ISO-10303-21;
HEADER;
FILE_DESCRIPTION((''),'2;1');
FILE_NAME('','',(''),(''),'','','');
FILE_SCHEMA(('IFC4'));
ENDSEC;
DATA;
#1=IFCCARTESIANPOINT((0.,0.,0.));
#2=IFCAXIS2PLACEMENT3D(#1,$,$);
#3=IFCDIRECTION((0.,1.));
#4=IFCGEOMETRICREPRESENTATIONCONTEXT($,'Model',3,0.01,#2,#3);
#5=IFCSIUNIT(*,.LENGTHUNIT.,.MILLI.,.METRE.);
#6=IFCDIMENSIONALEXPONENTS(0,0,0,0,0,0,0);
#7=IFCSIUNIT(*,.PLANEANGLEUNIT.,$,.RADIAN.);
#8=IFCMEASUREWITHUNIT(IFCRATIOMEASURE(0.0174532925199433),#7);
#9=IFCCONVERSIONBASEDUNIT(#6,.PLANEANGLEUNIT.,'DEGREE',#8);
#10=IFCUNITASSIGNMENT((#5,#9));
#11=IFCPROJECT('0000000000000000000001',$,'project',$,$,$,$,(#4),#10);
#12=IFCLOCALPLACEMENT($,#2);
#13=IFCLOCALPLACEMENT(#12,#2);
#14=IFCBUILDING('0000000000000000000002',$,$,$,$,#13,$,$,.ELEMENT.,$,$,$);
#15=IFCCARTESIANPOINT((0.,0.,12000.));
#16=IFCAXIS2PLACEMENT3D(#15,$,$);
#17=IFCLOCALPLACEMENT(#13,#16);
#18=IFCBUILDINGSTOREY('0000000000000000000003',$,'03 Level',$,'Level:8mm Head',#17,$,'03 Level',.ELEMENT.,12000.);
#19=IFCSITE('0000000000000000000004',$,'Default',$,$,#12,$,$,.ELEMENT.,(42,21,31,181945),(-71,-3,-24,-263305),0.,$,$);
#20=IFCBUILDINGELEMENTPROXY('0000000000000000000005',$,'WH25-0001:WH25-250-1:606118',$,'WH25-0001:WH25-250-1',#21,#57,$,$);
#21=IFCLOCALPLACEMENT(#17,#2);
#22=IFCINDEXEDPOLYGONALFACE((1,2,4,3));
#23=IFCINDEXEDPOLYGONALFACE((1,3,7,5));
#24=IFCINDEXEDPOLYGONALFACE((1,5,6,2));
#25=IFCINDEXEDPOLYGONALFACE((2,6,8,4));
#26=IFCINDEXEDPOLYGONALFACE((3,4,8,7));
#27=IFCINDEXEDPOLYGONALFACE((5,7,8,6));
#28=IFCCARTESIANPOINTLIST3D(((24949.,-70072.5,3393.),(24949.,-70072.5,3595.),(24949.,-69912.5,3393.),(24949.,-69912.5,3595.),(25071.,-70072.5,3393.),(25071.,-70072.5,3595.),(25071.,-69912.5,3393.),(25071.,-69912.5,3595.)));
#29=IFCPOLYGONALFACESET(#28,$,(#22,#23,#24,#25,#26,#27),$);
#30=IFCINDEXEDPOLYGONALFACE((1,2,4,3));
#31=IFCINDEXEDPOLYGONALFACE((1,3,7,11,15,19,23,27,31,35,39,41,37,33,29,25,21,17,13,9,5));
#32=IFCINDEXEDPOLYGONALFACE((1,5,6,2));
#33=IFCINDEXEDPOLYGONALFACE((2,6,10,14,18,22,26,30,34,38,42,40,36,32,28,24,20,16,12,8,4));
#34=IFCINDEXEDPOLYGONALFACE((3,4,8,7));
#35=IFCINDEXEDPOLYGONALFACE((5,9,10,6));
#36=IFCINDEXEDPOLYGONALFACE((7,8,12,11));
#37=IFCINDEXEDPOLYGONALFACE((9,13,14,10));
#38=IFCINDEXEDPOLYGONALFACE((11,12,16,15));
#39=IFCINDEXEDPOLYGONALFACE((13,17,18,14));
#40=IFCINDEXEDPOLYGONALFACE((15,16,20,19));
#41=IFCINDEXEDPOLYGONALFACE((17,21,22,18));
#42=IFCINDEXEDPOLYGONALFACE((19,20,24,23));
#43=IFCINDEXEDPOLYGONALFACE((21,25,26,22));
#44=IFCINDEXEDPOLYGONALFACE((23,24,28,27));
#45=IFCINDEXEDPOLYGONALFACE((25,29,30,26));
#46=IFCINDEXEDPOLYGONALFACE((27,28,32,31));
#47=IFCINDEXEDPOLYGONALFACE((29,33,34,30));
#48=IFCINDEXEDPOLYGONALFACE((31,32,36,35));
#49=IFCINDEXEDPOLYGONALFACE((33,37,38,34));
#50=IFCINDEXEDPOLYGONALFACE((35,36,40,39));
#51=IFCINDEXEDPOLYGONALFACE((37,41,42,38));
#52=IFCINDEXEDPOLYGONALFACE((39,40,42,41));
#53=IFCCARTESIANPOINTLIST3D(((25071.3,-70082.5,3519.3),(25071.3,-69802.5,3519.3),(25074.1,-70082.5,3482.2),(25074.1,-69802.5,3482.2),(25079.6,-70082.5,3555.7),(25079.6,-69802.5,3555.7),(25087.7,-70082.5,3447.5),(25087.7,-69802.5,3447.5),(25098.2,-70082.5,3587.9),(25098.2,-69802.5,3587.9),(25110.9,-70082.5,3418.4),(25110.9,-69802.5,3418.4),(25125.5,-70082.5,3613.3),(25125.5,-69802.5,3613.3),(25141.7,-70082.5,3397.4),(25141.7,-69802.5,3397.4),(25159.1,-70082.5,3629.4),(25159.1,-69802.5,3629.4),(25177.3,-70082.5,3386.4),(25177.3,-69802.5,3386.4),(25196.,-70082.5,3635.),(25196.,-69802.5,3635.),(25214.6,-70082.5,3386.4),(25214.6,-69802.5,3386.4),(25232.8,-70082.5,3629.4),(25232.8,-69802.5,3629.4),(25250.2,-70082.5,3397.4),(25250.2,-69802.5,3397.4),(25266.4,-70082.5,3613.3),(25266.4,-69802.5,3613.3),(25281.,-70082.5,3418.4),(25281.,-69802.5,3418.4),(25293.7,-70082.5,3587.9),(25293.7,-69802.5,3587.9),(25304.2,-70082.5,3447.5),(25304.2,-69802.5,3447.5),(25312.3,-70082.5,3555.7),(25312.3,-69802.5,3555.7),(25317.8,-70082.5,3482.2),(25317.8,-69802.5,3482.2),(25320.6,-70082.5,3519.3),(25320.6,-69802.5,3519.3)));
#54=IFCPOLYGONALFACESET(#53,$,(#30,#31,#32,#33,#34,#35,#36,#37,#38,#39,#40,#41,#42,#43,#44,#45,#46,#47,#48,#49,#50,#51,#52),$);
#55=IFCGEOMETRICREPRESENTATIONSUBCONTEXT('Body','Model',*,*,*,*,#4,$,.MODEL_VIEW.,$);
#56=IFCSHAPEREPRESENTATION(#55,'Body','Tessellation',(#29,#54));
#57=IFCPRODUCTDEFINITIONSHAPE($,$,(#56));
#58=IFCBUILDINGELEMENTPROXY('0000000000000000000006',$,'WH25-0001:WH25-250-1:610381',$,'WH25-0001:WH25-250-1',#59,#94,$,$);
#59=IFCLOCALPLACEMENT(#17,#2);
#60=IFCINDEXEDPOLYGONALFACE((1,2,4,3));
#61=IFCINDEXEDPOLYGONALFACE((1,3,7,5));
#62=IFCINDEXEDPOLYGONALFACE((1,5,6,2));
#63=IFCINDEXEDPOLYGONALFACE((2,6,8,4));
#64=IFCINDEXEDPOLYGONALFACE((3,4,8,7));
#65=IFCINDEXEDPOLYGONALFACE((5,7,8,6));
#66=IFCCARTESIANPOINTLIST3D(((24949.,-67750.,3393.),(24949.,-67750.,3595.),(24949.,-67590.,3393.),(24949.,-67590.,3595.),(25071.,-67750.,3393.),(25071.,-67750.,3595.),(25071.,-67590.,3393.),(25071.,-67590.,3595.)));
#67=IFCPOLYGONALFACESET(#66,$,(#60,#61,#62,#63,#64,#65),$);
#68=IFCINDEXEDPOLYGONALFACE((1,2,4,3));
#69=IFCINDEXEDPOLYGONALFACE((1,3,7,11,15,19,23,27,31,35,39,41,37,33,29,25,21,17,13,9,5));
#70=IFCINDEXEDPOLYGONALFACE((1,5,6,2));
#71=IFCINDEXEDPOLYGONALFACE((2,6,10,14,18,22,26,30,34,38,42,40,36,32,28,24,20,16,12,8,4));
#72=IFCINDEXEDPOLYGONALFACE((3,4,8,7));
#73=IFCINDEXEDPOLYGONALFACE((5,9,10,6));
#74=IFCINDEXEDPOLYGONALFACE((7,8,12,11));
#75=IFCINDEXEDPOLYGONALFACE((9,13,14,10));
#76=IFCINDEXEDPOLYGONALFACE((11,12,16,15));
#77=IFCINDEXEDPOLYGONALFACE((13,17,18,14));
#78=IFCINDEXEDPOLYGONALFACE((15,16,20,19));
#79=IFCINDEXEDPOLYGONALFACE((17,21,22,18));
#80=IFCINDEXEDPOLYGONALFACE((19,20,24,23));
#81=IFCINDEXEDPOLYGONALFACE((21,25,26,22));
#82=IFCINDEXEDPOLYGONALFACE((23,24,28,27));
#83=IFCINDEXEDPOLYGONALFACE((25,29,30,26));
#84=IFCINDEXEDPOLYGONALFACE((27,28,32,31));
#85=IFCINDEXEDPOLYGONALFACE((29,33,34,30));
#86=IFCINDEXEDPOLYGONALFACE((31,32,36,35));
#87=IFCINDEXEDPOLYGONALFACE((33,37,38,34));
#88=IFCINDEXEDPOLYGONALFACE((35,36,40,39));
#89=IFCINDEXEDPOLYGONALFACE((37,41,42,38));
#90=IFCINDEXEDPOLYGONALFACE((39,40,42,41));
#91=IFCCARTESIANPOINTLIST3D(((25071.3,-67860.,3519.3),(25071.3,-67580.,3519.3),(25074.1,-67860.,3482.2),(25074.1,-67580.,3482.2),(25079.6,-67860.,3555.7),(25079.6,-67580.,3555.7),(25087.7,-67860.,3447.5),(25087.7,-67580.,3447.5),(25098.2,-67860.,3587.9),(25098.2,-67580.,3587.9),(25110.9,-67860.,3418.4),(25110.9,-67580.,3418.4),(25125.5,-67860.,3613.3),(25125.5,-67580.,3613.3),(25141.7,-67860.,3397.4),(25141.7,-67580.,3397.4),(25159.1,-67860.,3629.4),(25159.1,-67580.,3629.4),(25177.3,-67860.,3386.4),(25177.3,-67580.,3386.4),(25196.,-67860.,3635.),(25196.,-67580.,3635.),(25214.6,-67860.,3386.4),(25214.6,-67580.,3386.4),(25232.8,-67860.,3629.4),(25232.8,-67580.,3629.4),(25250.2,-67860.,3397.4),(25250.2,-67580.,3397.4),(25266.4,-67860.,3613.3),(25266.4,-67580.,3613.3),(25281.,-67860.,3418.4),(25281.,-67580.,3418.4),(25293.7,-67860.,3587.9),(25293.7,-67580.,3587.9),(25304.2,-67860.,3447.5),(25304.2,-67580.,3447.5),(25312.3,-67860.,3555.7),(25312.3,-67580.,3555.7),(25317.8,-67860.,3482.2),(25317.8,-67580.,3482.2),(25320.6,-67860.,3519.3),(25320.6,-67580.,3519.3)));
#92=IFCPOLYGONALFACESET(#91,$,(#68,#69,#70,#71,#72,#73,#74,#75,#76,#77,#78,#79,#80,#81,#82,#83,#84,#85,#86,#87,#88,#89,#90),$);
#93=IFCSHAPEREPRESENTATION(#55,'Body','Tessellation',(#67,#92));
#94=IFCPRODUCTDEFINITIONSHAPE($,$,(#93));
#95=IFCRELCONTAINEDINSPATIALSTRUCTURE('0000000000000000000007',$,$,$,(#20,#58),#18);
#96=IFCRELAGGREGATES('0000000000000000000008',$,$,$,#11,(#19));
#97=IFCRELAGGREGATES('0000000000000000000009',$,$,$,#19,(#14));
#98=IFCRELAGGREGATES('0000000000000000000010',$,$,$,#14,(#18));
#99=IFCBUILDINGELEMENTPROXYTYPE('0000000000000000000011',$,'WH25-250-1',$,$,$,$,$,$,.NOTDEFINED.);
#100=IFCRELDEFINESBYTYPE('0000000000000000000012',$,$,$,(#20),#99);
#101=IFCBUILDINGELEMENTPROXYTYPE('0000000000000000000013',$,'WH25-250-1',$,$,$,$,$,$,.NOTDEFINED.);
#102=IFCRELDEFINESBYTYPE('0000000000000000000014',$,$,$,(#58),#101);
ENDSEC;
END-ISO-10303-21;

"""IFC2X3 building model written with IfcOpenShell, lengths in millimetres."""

from ifc_helpers import new_model, entity, si_unit, converted_unit, direction, frame, frame_2d, origin, origin_2d_with_axis, place, context, subcontext, project, spatial, rectangle, circle, extrude, source, transform, mapped, type_object, type_shapes, element, save


model = new_model("IFC2X3")

# Units and contexts
model_context = context("Model", 3, precision=0.01, world=origin(), true_north=direction((0.0, 1.0)))
body_context = subcontext(model_context, "Body", "Model", "MODEL_VIEW")
ifc_project = project(units=[si_unit("LENGTHUNIT", "METRE", prefix="MILLI"), converted_unit("PLANEANGLEUNIT", "DEGREE", entity("IfcRatioMeasure", 0.0174532925199433), si_unit("PLANEANGLEUNIT", "RADIAN"), dimensions=[0, 0, 0, 0, 0, 0, 0])], contexts=[model_context])

# Site, building, storey
site_placement = place(None, origin())
site = spatial("IfcSite", under=ifc_project, at=site_placement, Name="Default", CompositionType="ELEMENT", RefLatitude=(42, 21, 31, 181945), RefLongitude=(-71, -3, -24, -263305), RefElevation=0.0)
building_placement = place(site_placement, origin())
building = spatial("IfcBuilding", under=site, at=building_placement, CompositionType="ELEMENT")
storey_placement = place(building_placement, frame((0.0, 0.0, 12000.0)))
storey = spatial("IfcBuildingStorey", under=building, at=storey_placement, Name="03 Level", ObjectType="Level:8mm Head", LongName="03 Level", CompositionType="ELEMENT", Elevation=12000.0)

# Building element proxies
building_element_proxy_type_1 = type_object("IfcBuildingElementProxyType", Name="WH25-250-1", PredefinedType="NOTDEFINED")
shared_shape_1 = source(origin(), body_context, "Body", "SweptSolid", [
    extrude(rectangle(XDim=202.0, YDim=160.0, at=origin_2d_with_axis()), frame((50.0, -16.0, 125.0), z_axis=(0.0, 0.0, 1.0), x_axis=(0.0, -1.0, 0.0)), (0.0, 0.0, 1.0), 122.0),
    extrude(circle(Radius=125.0, at=frame_2d((0.0, 0.0), x_axis=(1.0, 0.0))), frame((-140.0, 0.0, 0.0), z_axis=(1.0, 0.0, 0.0), x_axis=(0.0, 1.0, 0.0)), (0.0, 0.0, 1.0), 280.0),
])
type_shapes(building_element_proxy_type_1, [shared_shape_1])
proxy_1_placement = place(storey_placement, frame((25196.0, -69942.5, 3510.0), z_axis=(-1.0, 0.0, 0.0), x_axis=(0.0, -1.0, 0.0)))
element("IfcBuildingElementProxy", 1, at=proxy_1_placement, inside=storey, type_object=building_element_proxy_type_1, Name="WH25-0001:WH25-250-1:606118", ObjectType="WH25-0001:WH25-250-1", context=body_context, shape_type="MappedRepresentation", body=[
    mapped(shared_shape_1, transform((0.0, 0.0, 0.0), scale=1.0)),
])
building_element_proxy_type_2 = type_object("IfcBuildingElementProxyType", Name="WH25-250-1", PredefinedType="NOTDEFINED")
shared_shape_2 = source(origin(), body_context, "Body", "SweptSolid", [
    extrude(rectangle(XDim=160.0, YDim=202.0, at=origin_2d_with_axis()), frame((50.0, 16.0, 125.0)), (0.0, 0.0, 1.0), 122.0),
    extrude(circle(Radius=125.0, at=frame_2d((0.0, 0.0), x_axis=(1.0, 0.0))), frame((-140.0, 0.0, 0.0), z_axis=(1.0, 0.0, 0.0), x_axis=(0.0, -1.0, 0.0)), (0.0, 0.0, 1.0), 280.0),
])
type_shapes(building_element_proxy_type_2, [shared_shape_2])
proxy_2_placement = place(storey_placement, frame((25196.0, -67720.0, 3510.0), z_axis=(-1.0, 0.0, 0.0), x_axis=(0.0, 1.0, 0.0)))
element("IfcBuildingElementProxy", 2, at=proxy_2_placement, inside=storey, type_object=building_element_proxy_type_2, Name="WH25-0001:WH25-250-1:610381", ObjectType="WH25-0001:WH25-250-1", context=body_context, shape_type="MappedRepresentation", body=[
    mapped(shared_shape_2, transform((0.0, 0.0, 0.0), scale=1.0)),
])

save(model, "model.ifc")
